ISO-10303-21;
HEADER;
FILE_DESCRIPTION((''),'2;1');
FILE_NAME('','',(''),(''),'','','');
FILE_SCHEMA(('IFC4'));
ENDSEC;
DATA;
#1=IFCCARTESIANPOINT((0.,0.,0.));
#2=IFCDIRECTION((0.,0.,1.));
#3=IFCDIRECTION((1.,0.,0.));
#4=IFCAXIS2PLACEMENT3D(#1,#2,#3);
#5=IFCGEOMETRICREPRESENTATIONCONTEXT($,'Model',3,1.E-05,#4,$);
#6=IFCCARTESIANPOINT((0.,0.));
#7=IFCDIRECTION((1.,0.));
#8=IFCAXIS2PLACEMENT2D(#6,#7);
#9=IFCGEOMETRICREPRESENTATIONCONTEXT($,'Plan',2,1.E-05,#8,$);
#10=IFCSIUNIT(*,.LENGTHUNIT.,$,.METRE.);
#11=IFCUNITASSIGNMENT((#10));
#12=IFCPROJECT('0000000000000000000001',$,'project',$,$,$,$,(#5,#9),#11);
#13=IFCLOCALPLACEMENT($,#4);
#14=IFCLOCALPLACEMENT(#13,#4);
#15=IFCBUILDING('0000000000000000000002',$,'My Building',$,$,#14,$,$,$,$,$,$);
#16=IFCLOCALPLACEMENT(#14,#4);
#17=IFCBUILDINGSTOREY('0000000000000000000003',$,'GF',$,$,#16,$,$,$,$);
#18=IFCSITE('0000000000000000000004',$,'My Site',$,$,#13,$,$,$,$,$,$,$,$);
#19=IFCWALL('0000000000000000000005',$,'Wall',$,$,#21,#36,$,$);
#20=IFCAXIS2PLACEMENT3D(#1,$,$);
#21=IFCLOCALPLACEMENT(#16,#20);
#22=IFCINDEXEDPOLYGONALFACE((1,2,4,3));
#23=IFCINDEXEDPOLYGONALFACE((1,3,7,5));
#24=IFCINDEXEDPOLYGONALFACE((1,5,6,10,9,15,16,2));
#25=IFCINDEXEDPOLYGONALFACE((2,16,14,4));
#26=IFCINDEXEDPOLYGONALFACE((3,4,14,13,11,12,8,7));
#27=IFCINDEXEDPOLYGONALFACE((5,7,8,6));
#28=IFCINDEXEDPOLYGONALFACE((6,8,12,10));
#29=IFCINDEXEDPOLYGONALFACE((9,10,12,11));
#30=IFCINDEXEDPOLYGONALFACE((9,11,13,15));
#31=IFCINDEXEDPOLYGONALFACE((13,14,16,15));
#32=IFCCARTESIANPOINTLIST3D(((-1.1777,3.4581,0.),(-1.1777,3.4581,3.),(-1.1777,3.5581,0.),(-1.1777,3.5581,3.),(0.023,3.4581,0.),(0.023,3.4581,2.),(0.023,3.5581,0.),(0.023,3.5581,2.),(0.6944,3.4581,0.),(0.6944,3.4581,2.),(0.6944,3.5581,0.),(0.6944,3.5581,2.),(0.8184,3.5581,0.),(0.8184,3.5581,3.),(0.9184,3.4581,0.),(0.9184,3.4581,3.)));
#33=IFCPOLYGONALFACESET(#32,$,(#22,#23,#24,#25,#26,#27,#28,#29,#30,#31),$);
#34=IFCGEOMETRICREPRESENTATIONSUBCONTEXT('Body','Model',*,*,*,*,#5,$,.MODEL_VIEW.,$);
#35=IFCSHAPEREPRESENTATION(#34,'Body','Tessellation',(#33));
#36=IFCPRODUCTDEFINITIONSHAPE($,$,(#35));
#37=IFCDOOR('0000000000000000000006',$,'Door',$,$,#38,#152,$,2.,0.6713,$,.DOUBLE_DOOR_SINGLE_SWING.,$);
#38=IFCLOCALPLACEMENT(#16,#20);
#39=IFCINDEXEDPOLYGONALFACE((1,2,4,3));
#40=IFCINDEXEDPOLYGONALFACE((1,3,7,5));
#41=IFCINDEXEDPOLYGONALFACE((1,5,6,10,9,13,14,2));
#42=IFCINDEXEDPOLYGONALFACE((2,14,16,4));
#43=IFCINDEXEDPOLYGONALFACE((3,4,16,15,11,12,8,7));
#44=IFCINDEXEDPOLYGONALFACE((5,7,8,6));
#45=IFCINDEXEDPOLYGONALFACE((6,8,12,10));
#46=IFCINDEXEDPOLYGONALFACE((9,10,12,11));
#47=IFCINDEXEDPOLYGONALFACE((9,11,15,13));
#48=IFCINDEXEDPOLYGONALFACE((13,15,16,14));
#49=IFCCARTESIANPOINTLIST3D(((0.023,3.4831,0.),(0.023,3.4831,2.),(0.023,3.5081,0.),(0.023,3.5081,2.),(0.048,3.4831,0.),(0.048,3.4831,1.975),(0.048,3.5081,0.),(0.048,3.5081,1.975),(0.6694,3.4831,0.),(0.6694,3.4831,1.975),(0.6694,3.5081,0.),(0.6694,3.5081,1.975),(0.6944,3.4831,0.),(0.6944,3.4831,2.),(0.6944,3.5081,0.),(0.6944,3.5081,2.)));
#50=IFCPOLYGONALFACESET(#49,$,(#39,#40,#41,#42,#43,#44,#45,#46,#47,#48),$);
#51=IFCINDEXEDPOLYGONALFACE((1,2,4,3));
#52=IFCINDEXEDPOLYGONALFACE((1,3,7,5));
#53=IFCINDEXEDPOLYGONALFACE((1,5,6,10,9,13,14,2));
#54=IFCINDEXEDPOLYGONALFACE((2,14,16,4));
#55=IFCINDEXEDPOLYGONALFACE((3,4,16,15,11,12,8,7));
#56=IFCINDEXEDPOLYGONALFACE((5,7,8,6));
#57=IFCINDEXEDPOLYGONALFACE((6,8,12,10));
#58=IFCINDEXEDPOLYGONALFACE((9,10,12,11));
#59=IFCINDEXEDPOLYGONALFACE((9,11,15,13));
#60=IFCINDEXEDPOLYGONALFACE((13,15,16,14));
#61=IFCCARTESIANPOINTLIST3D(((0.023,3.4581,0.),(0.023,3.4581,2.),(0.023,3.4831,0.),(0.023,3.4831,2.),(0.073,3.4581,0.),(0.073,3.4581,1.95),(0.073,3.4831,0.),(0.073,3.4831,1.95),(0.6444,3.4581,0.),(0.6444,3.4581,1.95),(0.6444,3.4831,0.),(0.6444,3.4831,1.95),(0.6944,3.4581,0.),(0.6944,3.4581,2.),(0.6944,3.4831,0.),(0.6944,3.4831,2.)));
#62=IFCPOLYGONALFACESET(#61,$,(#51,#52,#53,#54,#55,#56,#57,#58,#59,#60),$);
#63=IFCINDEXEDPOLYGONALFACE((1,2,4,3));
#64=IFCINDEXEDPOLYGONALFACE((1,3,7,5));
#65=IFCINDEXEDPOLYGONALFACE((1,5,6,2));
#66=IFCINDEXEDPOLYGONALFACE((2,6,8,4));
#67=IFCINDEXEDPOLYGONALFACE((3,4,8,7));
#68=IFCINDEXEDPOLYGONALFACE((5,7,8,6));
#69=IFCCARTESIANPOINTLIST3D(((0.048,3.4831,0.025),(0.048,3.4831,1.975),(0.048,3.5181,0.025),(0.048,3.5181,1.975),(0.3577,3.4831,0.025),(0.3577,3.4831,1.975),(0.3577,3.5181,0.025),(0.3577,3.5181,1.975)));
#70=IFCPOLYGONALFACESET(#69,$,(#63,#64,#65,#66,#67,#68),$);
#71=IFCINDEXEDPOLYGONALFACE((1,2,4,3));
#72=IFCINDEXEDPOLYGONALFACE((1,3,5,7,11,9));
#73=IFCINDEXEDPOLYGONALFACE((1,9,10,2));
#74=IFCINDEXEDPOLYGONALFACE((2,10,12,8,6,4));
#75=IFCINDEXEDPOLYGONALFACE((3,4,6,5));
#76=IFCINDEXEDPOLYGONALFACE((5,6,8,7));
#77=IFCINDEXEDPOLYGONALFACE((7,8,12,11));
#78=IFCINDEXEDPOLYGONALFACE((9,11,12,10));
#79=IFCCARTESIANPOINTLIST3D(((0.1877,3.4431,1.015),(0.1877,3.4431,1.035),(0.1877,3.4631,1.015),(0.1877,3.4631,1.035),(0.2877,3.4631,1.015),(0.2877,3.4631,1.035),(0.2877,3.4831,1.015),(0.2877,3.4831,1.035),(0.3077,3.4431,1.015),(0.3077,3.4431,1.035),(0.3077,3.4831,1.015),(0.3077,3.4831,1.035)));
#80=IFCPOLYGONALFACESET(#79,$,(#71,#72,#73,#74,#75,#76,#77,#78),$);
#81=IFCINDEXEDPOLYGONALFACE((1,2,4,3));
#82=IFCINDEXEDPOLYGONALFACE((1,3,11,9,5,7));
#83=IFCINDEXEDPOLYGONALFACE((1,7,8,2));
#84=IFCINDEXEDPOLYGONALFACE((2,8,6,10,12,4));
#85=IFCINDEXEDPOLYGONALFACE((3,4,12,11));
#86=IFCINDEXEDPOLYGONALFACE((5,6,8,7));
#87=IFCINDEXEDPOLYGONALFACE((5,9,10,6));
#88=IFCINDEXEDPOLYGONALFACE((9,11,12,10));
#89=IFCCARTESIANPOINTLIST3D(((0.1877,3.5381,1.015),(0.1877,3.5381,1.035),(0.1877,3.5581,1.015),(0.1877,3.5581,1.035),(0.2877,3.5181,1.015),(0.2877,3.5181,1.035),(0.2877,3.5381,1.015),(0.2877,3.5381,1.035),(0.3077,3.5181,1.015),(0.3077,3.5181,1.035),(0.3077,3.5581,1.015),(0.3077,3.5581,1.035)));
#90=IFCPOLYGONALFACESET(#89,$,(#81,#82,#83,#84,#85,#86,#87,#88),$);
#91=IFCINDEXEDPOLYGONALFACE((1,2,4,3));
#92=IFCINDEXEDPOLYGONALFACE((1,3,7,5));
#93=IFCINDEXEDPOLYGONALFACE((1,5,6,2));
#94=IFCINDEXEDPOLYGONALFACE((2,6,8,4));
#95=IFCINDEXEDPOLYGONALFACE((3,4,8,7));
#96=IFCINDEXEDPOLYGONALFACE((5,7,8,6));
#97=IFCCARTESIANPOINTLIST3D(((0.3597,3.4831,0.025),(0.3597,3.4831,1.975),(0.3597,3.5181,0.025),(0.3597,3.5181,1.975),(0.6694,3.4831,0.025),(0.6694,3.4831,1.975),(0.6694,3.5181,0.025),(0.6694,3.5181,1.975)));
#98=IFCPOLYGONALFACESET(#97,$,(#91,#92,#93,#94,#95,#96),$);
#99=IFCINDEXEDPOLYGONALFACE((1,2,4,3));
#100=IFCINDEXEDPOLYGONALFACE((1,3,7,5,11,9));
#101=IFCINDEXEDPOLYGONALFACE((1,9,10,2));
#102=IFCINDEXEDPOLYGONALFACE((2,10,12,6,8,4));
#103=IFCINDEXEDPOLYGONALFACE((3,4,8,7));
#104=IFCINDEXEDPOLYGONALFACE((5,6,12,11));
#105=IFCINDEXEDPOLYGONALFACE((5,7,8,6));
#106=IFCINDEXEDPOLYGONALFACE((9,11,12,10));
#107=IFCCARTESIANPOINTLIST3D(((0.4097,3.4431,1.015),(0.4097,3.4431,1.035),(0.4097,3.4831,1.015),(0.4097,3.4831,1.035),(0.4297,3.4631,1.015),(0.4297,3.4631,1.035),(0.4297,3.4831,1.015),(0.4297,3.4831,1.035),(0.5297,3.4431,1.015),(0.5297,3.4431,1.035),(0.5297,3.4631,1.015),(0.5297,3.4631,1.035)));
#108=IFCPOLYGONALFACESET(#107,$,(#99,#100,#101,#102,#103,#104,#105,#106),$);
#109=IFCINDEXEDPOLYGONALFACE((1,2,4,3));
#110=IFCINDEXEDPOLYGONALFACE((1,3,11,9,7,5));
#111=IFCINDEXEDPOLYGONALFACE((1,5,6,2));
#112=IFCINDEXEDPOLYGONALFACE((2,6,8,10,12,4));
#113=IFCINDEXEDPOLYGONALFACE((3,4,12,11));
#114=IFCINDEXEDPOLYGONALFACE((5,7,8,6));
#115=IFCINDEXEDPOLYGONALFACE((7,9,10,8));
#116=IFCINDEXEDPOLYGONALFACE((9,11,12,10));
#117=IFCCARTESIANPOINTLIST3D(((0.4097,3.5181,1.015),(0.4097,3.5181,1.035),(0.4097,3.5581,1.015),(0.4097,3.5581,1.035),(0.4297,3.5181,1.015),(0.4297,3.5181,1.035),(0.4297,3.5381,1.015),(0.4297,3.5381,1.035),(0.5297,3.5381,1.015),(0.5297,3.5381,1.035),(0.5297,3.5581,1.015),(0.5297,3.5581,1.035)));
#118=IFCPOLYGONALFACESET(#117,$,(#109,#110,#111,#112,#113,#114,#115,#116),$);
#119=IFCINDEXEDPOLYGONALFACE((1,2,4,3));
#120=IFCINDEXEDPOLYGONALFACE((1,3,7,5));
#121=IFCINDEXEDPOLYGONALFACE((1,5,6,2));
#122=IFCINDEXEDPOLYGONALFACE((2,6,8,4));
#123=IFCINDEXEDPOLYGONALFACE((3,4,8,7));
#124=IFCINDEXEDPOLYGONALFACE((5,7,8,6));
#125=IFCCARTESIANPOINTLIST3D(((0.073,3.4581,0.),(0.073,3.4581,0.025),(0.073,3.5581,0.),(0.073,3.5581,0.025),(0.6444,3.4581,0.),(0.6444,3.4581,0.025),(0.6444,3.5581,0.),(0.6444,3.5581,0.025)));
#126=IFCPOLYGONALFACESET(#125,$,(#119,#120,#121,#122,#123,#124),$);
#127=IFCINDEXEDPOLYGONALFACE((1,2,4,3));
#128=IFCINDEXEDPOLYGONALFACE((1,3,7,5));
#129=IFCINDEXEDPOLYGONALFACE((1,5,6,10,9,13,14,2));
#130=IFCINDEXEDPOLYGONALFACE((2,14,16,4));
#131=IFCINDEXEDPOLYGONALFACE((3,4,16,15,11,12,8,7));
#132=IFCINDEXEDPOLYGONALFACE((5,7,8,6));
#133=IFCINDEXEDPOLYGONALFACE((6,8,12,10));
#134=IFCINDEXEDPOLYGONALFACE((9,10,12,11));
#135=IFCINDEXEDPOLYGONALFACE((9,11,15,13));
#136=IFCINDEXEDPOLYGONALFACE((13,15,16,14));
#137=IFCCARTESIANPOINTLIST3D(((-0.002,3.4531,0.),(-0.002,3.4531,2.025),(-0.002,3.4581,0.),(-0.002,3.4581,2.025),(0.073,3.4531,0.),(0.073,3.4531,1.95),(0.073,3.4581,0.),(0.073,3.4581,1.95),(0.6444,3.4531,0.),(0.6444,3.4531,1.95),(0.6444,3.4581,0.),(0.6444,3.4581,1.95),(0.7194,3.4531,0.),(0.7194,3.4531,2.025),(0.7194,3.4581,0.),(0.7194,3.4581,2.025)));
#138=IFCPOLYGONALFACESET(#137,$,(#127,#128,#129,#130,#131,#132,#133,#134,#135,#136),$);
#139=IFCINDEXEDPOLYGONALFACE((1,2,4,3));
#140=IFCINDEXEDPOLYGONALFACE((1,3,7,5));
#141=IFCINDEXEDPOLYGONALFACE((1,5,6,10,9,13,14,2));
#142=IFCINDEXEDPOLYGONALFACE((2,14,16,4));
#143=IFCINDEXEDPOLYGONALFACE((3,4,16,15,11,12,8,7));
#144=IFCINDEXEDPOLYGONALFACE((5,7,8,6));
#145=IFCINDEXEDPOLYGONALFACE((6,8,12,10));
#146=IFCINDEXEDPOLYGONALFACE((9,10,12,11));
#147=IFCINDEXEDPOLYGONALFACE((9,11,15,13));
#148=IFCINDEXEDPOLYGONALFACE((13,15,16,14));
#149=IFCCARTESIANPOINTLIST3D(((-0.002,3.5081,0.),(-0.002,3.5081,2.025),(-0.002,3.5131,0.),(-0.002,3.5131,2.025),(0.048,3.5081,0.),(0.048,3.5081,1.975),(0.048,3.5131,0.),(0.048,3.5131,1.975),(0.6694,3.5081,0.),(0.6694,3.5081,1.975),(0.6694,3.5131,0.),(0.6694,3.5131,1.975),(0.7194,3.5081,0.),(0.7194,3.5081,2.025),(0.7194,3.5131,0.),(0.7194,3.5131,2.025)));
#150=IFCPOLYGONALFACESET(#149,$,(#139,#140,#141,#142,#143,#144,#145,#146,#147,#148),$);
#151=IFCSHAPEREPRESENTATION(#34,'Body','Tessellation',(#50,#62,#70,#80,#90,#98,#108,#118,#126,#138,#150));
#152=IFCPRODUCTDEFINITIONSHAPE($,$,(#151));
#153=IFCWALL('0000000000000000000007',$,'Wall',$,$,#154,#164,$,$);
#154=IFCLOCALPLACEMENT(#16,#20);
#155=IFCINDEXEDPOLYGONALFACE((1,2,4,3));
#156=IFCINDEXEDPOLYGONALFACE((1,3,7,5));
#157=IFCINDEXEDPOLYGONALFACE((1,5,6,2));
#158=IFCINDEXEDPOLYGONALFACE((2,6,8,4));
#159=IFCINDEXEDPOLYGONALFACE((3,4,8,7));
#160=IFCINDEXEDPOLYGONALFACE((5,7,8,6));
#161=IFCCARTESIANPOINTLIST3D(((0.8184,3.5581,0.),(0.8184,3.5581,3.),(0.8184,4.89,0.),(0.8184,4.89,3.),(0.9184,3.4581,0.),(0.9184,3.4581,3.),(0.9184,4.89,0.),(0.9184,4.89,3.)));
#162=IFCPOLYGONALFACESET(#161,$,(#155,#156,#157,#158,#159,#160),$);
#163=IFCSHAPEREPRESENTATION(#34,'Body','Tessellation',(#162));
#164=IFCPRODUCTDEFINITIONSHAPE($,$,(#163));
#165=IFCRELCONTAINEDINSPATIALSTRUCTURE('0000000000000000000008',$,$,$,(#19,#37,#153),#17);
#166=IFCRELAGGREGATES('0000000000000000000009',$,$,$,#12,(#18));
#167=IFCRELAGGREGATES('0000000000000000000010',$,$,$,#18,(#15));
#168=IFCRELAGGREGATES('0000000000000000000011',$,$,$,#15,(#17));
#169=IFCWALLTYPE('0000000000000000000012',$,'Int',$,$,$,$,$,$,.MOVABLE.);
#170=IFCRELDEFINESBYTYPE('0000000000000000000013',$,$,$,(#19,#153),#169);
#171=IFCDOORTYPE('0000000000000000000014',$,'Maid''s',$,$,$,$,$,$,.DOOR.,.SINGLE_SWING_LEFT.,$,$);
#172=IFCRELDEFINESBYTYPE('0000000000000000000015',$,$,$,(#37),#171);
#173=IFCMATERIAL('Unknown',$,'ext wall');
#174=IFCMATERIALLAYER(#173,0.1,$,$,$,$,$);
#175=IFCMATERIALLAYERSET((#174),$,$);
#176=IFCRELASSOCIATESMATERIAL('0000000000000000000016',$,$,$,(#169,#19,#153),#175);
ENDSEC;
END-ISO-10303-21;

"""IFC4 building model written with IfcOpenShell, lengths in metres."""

from ifc_helpers import new_model, entity, si_unit, frame, origin_with_axes, origin_2d_with_axis, place, context, subcontext, project, spatial, line, indexed_curve, outline, extrude, shape, source, transform, mapped, material, layer, layer_set, layer_usage, type_object, type_shapes, element, fill, save


model = new_model("IFC4")

# Units and contexts
model_context = context("Model", 3, precision=1e-05, world=origin_with_axes())
plan_context = context("Plan", 2, precision=1e-05, world=origin_2d_with_axis())
body_context_1 = subcontext(model_context, "Body", "Model", "MODEL_VIEW")
body_context_2 = subcontext(plan_context, "Body", "Plan", "PLAN_VIEW")
ifc_project = project(units=[si_unit("LENGTHUNIT", "METRE")], contexts=[model_context, plan_context])

# Site, building, storey
site_placement = place(None, origin_with_axes())
site = spatial("IfcSite", under=ifc_project, at=site_placement, Name="My Site")
building_placement = place(site_placement, origin_with_axes())
building = spatial("IfcBuilding", under=site, at=building_placement, Name="My Building")
storey_placement = place(building_placement, origin_with_axes())
storey = spatial("IfcBuildingStorey", under=building, at=storey_placement, Name="GF")

# Shared definitions
ifc_material = material(Name="Unknown", Category="ext wall")

# Shared definitions
ifc_layer_1 = layer(ifc_material, 0.1)
ifc_layer_set_1 = layer_set([ifc_layer_1])
wall_type_1 = type_object("IfcWallType", Name="Int", PredefinedType="MOVABLE", material=ifc_layer_set_1)

# Wall, opening, door
ifc_layer_usage_1 = layer_usage(ifc_layer_set_1, "AXIS2", "POSITIVE", 0.0)
wall_1_placement = place(storey_placement, frame((-1.1777, 3.4581, 0.0), z_axis=(0.0, 0.0, 1.0), x_axis=(1.0, 0.0, 0.0)))
wall_1 = element("IfcWall", 1, at=wall_1_placement, inside=storey, type_object=wall_type_1, material=ifc_layer_usage_1, Name="Wall", context=body_context_1, shape_type="SweptSolid", body=[
    extrude(outline(indexed_curve([(0.0, 0.0), (0.0, 0.1), (1.9961, 0.1), (2.0961, 0.0)], segments=[line(1, 2, 3, 4, 1)])), origin_with_axes(), (0.0, 0.0, 1.0), 3.0),
])
shared_shape_1 = source(origin_with_axes(), body_context_1, "Body", "SweptSolid", [
    extrude(outline(indexed_curve([(0.0, 0.0), (0.6713, 0.0), (0.6713, 2.0), (0.0, 2.0)], segments=[line(1, 2, 3, 4, 1)])), frame((0.0, -0.6, 0.0), z_axis=(0.0, -1.0, 0.0), x_axis=(1.0, 0.0, 0.0)), (0.0, 0.0, -1.0), 1.2),
])
opening_1_placement = place(wall_1_placement, frame((1.2007, 0.0, 0.0), z_axis=(0.0, 0.0, 1.0), x_axis=(1.0, 0.0, 0.0)))
opening_1 = element("IfcOpeningElement", 2, at=opening_1_placement, cuts=wall_1, PredefinedType="OPENING", context=body_context_1, shape_type="MappedRepresentation", body=[
    mapped(shared_shape_1, transform((0.0, 0.0, 0.0), x_axis=(1.0, 0.0, 0.0), y_axis=(0.0, 1.0, 0.0), z_axis=(0.0, 0.0, 1.0), scale=1.0)),
])
door_type_1 = type_object("IfcDoorType", Name="Maid's", OperationType="SINGLE_SWING_LEFT", PredefinedType="DOOR")
shared_shape_2 = source(origin_with_axes(), body_context_1, "Body", "SweptSolid", [
    extrude(outline(indexed_curve([(0.0, 0.0), (0.0, 2.0), (0.6713, 2.0), (0.6713, 0.0), (0.6463, 0.0), (0.6463, 1.975), (0.025, 1.975), (0.025, 0.0)], segments=[line(1, 2, 3, 4, 5, 6, 7, 8, 1)])), frame((0.0, 0.025, 0.0), z_axis=(0.0, -1.0, 0.0), x_axis=(1.0, 0.0, 0.0)), (0.0, 0.0, -1.0), 0.025),
    extrude(outline(indexed_curve([(0.0, 0.0), (0.0, 2.0), (0.6713, 2.0), (0.6713, 0.0), (0.6213, 0.0), (0.6213, 1.95), (0.05, 1.95), (0.05, 0.0)], segments=[line(1, 2, 3, 4, 5, 6, 7, 8, 1)])), frame((0.0, 0.0, 0.0), z_axis=(0.0, -1.0, 0.0), x_axis=(1.0, 0.0, 0.0)), (0.0, 0.0, -1.0), 0.025),
    extrude(outline(indexed_curve([(0.0, 0.0), (0.3097, 0.0), (0.3097, 0.035), (0.0, 0.035)], segments=[line(1, 2, 3, 4, 1)])), frame((0.025, 0.025, 0.025), z_axis=(0.0, 0.0, 1.0), x_axis=(1.0, 0.0, 0.0)), (0.0, 0.0, 1.0), 1.95),
    extrude(outline(indexed_curve([(0.0, 0.0), (0.0, -0.04), (-0.12, -0.04), (-0.12, -0.02), (-0.02, -0.02), (-0.02, 0.0)], segments=[line(1, 2, 3, 4, 5, 6, 1)])), frame((0.2847, 0.025, 1.015), z_axis=(0.0, 0.0, 1.0), x_axis=(1.0, 0.0, 0.0)), (0.0, 0.0, 1.0), 0.02),
    extrude(outline(indexed_curve([(0.0, 0.0), (0.0, 0.04), (-0.12, 0.04), (-0.12, 0.02), (-0.02, 0.02), (-0.02, 0.0)], segments=[line(1, 2, 3, 4, 5, 6, 1)])), frame((0.2847, 0.06, 1.015), z_axis=(0.0, 0.0, 1.0), x_axis=(1.0, 0.0, 0.0)), (0.0, 0.0, 1.0), 0.02),
    extrude(outline(indexed_curve([(0.0, 0.0), (-0.3097, 0.0), (-0.3097, 0.035), (0.0, 0.035)], segments=[line(1, 2, 3, 4, 1)])), frame((0.6463, 0.025, 0.025), z_axis=(0.0, 0.0, 1.0), x_axis=(1.0, 0.0, 0.0)), (0.0, 0.0, 1.0), 1.95),
    extrude(outline(indexed_curve([(0.0, 0.0), (0.0, -0.04), (0.12, -0.04), (0.12, -0.02), (0.02, -0.02), (0.02, 0.0)], segments=[line(1, 2, 3, 4, 5, 6, 1)])), frame((0.3867, 0.025, 1.015), z_axis=(0.0, 0.0, 1.0), x_axis=(1.0, 0.0, 0.0)), (0.0, 0.0, 1.0), 0.02),
    extrude(outline(indexed_curve([(0.0, 0.0), (0.0, 0.04), (0.12, 0.04), (0.12, 0.02), (0.02, 0.02), (0.02, 0.0)], segments=[line(1, 2, 3, 4, 5, 6, 1)])), frame((0.3867, 0.06, 1.015), z_axis=(0.0, 0.0, 1.0), x_axis=(1.0, 0.0, 0.0)), (0.0, 0.0, 1.0), 0.02),
    extrude(outline(indexed_curve([(0.0, 0.0), (0.5713, 0.0), (0.5713, 0.1), (0.0, 0.1)], segments=[line(1, 2, 3, 4, 1)])), frame((0.05, 0.0, 0.0), z_axis=(0.0, 0.0, 1.0), x_axis=(1.0, 0.0, 0.0)), (0.0, 0.0, 1.0), 0.025),
    extrude(outline(indexed_curve([(0.0, 0.0), (0.0, 2.025), (0.7213, 2.025), (0.7213, 0.0), (0.6463, 0.0), (0.6463, 1.95), (0.075, 1.95), (0.075, 0.0)], segments=[line(1, 2, 3, 4, 5, 6, 7, 8, 1)])), frame((-0.025, -0.005, 0.0), z_axis=(0.0, -1.0, 0.0), x_axis=(1.0, 0.0, 0.0)), (0.0, 0.0, -1.0), 0.005),
    extrude(outline(indexed_curve([(0.0, 0.0), (0.0, 2.025), (0.7213, 2.025), (0.7213, 0.0), (0.6713, 0.0), (0.6713, 1.975), (0.05, 1.975), (0.05, 0.0)], segments=[line(1, 2, 3, 4, 5, 6, 7, 8, 1)])), frame((-0.025, 0.05, 0.0), z_axis=(0.0, -1.0, 0.0), x_axis=(1.0, 0.0, 0.0)), (0.0, 0.0, -1.0), 0.005),
])
shared_shape_3 = source(origin_with_axes(), body_context_2, "Body", "Curve2D", [
    entity("IfcIndexedPolyCurve", entity("IfcCartesianPointList2D", [[0.0, 0.0], [0.0, 0.05], [0.025, 0.05], [0.025, 0.025], [0.05, 0.025], [0.05, 0.0]]), [entity("IfcLineIndex", [1, 2, 3, 4, 5, 6, 1])]),
    entity("IfcIndexedPolyCurve", entity("IfcCartesianPointList2D", [[0.6713, 0.0], [0.6713, 0.05], [0.6463, 0.05], [0.6463, 0.025], [0.6213, 0.025], [0.6213, 0.0]]), [entity("IfcLineIndex", [1, 2, 3, 4, 5, 6, 1])]),
    entity("IfcTrimmedCurve", entity("IfcEllipse", entity("IfcAxis2Placement2D", entity("IfcCartesianPoint", [0.06, 0.05]), entity("IfcDirection", [1.0, 0.0])), 0.2757, 0.3107), [entity("IfcCartesianPoint", [0.3357, 0.05])], [entity("IfcCartesianPoint", [0.06, 0.3607])], True, "CARTESIAN"),
    entity("IfcIndexedPolyCurve", entity("IfcCartesianPointList2D", [[0.025, 0.05], [0.06, 0.05], [0.06, 0.3607], [0.025, 0.3607]]), [entity("IfcLineIndex", [1, 2, 3, 4, 1])]),
    entity("IfcTrimmedCurve", entity("IfcEllipse", entity("IfcAxis2Placement2D", entity("IfcCartesianPoint", [0.6113, 0.05]), entity("IfcDirection", [1.0, 0.0])), 0.2757, 0.3107), [entity("IfcCartesianPoint", [0.6113, 0.3607])], [entity("IfcCartesianPoint", [0.3357, 0.05])], True, "CARTESIAN"),
    entity("IfcIndexedPolyCurve", entity("IfcCartesianPointList2D", [[0.6463, 0.05], [0.6113, 0.05], [0.6113, 0.3607], [0.6463, 0.3607]]), [entity("IfcLineIndex", [1, 2, 3, 4, 1])]),
])
type_shapes(door_type_1, [shared_shape_2, shared_shape_3])
door_1_placement = place(opening_1_placement, origin_with_axes())
door_1 = element("IfcDoor", 3, at=door_1_placement, inside=storey, type_object=door_type_1, Name="Door", OperationType="DOUBLE_DOOR_SINGLE_SWING", OverallHeight=2.0, OverallWidth=0.6713, shapes=[
    shape(body_context_1, "Body", "MappedRepresentation", [mapped(shared_shape_2, transform((0.0, 0.0, 0.0), x_axis=(1.0, 0.0, 0.0), y_axis=(0.0, 1.0, 0.0), z_axis=(0.0, 0.0, 1.0), scale=1.0))]),
    shape(body_context_2, "Body", "MappedRepresentation", [mapped(shared_shape_3, transform((0.0, 0.0, 0.0), x_axis=(1.0, 0.0, 0.0), y_axis=(0.0, 1.0, 0.0), z_axis=(0.0, 0.0, 1.0), scale=1.0))]),
])
fill(opening_1, door_1)

# Wall
ifc_layer_usage_2 = layer_usage(ifc_layer_set_1, "AXIS2", "POSITIVE", 0.0)
wall_2_placement = place(storey_placement, frame((0.9184, 3.4581, 0.0), z_axis=(0.0, 0.0, 1.0), x_axis=(0.0, 1.0, 0.0)))
element("IfcWall", 4, at=wall_2_placement, inside=storey, type_object=wall_type_1, material=ifc_layer_usage_2, Name="Wall", context=body_context_1, shape_type="SweptSolid", body=[
    extrude(outline(indexed_curve([(0.0, 0.0), (0.1, 0.1), (1.4319, 0.1), (1.4319, 0.0)], segments=[line(1, 2, 3, 4, 1)])), origin_with_axes(), (0.0, 0.0, 1.0), 3.0),
])

save(model, "model.ifc")
